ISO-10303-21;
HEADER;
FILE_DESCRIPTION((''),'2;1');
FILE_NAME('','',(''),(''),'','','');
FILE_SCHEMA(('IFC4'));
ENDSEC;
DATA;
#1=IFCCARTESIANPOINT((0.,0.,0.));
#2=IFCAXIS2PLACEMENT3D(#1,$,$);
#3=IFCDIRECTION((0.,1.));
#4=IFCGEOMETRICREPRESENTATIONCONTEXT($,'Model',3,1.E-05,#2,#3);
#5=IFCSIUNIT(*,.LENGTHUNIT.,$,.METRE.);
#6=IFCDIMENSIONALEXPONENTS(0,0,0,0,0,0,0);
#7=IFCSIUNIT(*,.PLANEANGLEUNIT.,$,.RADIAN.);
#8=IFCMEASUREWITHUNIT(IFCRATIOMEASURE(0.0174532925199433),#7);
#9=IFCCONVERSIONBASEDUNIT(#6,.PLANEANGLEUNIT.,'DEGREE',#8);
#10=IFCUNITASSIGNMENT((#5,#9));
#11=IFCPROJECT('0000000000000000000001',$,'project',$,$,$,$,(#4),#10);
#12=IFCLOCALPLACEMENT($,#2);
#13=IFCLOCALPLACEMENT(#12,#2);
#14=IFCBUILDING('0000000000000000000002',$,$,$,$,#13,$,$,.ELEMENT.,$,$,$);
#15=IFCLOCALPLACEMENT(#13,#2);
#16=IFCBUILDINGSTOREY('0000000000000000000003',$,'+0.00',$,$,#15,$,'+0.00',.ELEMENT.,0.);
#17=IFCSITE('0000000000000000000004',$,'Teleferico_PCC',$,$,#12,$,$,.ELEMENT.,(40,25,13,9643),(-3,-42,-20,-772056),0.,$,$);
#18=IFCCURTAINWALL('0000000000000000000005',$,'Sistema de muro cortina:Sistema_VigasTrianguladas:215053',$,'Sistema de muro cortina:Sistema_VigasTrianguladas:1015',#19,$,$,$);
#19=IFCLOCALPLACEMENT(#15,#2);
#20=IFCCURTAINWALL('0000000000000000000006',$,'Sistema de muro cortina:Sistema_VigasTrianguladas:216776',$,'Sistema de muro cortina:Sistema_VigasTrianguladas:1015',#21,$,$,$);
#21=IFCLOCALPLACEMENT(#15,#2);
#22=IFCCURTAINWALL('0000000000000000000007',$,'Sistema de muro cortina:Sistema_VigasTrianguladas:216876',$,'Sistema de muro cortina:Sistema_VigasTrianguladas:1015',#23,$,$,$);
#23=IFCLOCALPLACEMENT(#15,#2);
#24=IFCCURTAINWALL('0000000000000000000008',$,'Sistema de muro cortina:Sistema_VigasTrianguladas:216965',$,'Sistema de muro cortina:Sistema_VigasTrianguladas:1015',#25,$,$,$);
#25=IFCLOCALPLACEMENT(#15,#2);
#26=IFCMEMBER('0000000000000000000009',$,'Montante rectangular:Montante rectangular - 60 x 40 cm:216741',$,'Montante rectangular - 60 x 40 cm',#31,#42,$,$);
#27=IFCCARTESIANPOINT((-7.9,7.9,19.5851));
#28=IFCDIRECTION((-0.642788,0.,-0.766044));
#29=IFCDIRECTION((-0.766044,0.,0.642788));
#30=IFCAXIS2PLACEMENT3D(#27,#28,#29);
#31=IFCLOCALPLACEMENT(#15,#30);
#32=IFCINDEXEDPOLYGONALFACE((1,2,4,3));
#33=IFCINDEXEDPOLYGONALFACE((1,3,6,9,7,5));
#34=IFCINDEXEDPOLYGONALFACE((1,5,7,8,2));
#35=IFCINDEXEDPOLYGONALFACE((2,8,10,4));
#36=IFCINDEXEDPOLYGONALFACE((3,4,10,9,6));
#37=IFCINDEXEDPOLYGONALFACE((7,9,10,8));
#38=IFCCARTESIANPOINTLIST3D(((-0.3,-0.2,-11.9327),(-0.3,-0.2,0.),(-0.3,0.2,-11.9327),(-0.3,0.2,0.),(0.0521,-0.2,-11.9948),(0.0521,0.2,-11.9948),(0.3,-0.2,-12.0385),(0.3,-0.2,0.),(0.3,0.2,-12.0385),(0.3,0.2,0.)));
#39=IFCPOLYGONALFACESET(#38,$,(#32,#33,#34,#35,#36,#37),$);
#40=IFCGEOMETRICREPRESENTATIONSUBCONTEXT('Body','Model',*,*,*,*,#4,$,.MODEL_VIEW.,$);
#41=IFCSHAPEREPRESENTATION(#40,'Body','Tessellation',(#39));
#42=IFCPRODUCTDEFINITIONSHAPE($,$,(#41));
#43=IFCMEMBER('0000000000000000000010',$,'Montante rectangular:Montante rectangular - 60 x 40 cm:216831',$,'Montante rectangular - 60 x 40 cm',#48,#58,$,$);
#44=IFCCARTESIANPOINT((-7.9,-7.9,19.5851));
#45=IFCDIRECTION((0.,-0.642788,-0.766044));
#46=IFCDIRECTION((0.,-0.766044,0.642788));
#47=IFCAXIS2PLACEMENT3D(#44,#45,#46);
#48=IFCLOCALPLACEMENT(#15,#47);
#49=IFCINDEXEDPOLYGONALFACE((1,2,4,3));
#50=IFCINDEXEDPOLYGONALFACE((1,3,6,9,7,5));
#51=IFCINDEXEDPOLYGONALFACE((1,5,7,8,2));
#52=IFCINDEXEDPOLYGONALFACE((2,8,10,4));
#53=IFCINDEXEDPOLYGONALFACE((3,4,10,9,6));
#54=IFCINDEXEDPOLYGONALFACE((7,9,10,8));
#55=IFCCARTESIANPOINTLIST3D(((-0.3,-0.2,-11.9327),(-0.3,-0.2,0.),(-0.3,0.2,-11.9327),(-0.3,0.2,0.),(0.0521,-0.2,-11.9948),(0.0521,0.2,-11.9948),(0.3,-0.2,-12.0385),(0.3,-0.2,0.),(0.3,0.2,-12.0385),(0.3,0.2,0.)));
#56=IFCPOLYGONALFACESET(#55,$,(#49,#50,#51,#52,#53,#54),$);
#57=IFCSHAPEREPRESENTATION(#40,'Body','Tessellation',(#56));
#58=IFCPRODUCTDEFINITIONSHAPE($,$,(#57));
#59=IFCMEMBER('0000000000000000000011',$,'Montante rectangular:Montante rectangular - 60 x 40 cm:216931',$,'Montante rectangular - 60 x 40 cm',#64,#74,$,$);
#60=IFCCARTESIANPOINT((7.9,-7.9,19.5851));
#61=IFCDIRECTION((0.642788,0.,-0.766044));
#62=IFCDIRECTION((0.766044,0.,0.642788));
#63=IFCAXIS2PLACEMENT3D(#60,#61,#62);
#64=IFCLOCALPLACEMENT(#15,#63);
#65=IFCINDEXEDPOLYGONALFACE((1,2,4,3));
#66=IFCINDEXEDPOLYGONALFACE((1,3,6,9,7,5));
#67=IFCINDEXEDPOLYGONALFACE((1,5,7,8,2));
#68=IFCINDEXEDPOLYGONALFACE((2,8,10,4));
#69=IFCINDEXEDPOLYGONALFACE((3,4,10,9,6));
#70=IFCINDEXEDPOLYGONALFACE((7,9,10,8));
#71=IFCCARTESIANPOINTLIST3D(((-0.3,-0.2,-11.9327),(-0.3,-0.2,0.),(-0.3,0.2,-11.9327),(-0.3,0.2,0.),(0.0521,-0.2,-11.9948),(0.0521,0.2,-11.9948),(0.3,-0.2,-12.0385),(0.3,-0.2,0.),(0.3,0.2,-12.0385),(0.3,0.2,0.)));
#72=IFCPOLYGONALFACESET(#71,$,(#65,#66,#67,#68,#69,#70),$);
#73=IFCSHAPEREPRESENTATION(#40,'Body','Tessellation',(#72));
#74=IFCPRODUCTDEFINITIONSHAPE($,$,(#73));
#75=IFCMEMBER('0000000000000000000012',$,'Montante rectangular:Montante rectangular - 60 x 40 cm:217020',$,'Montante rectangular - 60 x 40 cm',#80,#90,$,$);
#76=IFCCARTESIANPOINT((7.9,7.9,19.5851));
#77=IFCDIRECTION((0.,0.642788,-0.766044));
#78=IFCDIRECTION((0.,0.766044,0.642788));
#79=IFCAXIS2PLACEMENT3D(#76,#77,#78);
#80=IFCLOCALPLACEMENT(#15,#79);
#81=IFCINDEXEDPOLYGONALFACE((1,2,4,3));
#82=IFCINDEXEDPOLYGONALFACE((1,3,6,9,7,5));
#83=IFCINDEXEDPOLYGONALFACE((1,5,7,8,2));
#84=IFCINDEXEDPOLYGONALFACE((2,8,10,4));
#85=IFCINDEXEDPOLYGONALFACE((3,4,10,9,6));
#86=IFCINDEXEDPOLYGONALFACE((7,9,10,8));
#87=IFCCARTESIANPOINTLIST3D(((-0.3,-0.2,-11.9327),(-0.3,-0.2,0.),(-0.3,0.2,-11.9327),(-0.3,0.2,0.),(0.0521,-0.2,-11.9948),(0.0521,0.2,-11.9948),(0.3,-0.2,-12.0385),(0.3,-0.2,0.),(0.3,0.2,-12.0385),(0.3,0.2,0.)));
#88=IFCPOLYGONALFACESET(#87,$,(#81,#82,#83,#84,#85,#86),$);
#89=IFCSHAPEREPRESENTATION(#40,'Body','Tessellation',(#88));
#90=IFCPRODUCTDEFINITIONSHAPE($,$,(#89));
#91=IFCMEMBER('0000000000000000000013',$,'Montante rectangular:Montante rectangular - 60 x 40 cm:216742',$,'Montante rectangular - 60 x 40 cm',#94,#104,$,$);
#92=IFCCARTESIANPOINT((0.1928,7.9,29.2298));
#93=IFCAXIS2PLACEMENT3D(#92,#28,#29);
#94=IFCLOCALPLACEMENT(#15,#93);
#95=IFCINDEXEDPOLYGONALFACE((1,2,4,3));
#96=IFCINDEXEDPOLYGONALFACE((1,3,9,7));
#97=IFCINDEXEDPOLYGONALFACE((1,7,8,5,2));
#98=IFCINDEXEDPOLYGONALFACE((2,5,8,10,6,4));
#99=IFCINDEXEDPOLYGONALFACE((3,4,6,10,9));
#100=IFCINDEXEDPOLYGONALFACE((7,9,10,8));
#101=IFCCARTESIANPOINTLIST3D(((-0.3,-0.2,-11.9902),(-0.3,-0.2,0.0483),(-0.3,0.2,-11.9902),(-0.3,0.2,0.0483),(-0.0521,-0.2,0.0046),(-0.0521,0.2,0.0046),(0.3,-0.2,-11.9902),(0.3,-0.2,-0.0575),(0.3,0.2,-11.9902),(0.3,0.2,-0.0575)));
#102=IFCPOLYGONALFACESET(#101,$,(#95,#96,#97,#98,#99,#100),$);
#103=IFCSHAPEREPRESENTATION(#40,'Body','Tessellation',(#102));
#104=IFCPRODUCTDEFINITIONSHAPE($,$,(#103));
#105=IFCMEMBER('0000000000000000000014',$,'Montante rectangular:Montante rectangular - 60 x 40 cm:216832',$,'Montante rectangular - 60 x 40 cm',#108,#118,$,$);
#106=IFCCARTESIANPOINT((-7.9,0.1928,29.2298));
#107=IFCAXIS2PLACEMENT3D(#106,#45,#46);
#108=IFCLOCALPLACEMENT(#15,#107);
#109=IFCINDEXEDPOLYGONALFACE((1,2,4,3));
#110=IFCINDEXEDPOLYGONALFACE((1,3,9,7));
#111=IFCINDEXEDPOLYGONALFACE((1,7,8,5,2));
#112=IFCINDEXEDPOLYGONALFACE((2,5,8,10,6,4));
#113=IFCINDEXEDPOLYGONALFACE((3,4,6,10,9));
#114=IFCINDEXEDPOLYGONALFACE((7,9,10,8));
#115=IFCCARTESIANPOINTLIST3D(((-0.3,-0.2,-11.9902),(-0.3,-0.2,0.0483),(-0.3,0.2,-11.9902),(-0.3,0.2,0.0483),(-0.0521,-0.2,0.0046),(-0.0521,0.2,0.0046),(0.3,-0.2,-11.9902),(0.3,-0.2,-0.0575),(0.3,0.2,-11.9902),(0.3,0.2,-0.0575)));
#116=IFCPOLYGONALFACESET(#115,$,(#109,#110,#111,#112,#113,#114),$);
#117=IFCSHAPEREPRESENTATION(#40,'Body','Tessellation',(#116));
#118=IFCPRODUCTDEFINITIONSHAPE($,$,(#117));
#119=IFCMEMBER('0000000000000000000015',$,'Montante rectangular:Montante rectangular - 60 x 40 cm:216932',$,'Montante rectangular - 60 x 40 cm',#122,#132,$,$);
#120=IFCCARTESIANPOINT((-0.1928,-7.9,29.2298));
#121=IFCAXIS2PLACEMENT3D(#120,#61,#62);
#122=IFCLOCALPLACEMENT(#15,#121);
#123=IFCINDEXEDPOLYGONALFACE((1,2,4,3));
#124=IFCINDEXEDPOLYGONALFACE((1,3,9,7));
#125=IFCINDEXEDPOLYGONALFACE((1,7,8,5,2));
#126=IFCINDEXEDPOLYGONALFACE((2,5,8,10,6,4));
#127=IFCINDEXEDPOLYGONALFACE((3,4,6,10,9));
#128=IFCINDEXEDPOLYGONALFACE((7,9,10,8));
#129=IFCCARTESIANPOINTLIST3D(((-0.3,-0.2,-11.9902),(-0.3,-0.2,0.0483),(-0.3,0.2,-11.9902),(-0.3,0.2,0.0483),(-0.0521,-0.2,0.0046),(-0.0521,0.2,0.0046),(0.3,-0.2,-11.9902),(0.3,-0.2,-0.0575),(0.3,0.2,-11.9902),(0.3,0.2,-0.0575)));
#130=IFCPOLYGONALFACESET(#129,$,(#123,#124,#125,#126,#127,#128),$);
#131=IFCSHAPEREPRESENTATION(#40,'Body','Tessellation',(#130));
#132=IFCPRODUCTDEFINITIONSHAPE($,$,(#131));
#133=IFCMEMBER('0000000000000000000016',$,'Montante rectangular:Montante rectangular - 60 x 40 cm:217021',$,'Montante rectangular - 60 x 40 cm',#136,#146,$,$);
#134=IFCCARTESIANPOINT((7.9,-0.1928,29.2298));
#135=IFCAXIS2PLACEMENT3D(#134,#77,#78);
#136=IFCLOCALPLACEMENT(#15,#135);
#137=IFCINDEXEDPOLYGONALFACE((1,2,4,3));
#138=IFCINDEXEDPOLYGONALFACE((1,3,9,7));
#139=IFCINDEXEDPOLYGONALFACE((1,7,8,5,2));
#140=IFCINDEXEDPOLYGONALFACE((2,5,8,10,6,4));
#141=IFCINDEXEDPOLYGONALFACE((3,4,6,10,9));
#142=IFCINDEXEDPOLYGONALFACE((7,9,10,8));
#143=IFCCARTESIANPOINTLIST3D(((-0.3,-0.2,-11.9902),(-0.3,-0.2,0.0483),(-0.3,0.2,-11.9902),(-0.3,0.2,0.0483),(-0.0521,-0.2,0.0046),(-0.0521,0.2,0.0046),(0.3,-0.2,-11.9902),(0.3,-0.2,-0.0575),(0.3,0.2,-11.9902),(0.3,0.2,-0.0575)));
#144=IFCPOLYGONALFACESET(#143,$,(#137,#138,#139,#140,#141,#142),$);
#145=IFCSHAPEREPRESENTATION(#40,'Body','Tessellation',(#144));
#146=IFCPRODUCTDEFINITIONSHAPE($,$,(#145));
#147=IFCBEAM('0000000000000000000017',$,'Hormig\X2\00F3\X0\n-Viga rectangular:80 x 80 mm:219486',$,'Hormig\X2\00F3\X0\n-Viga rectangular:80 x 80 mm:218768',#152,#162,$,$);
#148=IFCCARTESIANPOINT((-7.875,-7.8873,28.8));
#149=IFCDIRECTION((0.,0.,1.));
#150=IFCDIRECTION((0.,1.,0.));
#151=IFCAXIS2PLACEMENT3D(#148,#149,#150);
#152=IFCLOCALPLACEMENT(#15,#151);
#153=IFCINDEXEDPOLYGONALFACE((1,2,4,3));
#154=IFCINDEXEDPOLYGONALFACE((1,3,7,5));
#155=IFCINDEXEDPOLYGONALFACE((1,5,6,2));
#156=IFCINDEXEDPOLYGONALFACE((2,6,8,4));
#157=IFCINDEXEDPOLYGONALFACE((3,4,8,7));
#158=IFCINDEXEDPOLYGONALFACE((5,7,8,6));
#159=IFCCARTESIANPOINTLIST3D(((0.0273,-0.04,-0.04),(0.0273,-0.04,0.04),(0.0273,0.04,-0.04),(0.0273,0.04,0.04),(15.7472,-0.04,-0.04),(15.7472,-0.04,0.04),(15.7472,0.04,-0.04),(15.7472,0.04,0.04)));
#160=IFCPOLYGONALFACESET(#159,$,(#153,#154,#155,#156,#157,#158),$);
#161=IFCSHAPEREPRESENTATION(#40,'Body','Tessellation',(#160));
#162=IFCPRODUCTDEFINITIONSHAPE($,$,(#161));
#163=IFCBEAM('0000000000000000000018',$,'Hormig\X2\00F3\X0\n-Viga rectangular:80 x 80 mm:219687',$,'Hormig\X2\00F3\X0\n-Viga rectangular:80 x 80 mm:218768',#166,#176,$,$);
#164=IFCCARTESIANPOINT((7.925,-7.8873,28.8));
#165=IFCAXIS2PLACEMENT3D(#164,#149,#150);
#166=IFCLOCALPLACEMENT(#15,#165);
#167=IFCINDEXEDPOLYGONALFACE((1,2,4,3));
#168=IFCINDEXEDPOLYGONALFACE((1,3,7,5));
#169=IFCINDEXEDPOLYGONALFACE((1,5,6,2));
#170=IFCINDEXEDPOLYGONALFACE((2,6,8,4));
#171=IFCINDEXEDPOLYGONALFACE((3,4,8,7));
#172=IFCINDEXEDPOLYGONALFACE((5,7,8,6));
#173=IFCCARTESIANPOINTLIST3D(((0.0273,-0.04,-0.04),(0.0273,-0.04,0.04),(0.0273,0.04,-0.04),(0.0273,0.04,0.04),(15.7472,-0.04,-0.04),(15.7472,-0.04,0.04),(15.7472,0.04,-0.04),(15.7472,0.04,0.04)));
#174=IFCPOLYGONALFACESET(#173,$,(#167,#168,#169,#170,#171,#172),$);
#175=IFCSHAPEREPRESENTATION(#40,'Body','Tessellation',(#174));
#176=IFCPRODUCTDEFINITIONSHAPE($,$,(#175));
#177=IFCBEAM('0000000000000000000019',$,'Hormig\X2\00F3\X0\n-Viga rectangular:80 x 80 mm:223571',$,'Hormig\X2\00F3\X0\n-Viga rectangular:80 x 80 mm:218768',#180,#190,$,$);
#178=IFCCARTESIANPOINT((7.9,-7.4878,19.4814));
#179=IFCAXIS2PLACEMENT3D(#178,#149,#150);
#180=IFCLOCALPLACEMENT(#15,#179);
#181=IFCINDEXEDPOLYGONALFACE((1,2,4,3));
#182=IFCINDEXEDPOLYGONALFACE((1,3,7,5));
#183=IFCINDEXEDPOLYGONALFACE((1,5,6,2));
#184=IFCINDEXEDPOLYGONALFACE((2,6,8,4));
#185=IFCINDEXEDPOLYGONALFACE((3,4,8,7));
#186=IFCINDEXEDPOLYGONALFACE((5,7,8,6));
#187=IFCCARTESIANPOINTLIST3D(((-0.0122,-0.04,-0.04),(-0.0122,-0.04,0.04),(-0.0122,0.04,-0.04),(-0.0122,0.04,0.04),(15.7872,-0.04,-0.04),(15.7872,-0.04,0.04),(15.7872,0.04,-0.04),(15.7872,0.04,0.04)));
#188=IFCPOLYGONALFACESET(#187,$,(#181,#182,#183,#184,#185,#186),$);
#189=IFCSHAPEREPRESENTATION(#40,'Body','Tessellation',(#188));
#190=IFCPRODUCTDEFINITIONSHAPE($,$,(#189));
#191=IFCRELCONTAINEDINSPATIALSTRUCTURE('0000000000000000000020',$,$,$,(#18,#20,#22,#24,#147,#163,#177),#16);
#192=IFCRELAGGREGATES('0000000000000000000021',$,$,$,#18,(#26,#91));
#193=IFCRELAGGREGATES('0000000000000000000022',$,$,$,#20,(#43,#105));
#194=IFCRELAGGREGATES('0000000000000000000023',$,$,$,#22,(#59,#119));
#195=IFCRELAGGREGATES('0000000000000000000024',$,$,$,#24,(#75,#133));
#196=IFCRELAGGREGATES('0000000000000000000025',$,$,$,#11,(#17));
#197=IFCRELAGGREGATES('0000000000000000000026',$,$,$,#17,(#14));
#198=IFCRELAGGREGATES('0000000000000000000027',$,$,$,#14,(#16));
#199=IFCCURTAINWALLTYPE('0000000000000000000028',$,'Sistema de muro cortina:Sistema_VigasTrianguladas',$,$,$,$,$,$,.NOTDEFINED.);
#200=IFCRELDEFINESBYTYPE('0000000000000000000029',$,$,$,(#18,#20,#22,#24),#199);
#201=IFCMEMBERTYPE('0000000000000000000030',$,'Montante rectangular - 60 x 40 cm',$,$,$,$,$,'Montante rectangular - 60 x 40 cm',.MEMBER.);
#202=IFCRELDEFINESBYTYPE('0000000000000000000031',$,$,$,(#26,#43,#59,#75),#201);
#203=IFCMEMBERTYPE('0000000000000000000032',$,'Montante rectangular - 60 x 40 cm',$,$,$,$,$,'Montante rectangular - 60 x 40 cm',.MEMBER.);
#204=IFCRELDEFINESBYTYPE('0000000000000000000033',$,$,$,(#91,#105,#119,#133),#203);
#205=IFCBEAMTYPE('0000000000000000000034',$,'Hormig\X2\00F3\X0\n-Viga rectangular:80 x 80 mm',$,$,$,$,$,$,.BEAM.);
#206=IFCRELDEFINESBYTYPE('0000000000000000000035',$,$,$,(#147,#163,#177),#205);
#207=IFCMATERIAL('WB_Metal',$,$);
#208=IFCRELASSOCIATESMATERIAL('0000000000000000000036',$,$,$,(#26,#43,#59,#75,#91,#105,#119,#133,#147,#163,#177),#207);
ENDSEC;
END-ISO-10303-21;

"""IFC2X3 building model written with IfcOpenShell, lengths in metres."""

from ifc_helpers import new_model, entity, si_unit, converted_unit, direction, frame, frame_2d, origin, origin_2d_with_axis, place, context, subcontext, project, spatial, polyline, rectangle, extrude, clip, bounded_halfspace, source, transform, mapped, material, type_object, type_shapes, element, aggregate, save


model = new_model("IFC2X3")

# Units and contexts
model_context = context("Model", 3, precision=1e-05, world=origin(), true_north=direction((0.0, 1.0)))
body_context = subcontext(model_context, "Body", "Model", "MODEL_VIEW")
ifc_project = project(units=[si_unit("LENGTHUNIT", "METRE"), converted_unit("PLANEANGLEUNIT", "DEGREE", entity("IfcRatioMeasure", 0.0174532925199433), si_unit("PLANEANGLEUNIT", "RADIAN"), dimensions=[0, 0, 0, 0, 0, 0, 0])], contexts=[model_context])

# Site, building, storey
site_placement = place(None, origin())
site = spatial("IfcSite", under=ifc_project, at=site_placement, Name="Teleferico_PCC", CompositionType="ELEMENT", RefLatitude=(40, 25, 13, 9643), RefLongitude=(-3, -42, -20, -772056), RefElevation=0.0)
building_placement = place(site_placement, origin())
building = spatial("IfcBuilding", under=site, at=building_placement, CompositionType="ELEMENT")
storey_placement = place(building_placement, origin())
storey = spatial("IfcBuildingStorey", under=building, at=storey_placement, Name="+0.00", LongName="+0.00", CompositionType="ELEMENT", Elevation=0.0)

# Curtain walls
curtain_wall_type = type_object("IfcCurtainWallType", Name="Sistema de muro cortina:Sistema_VigasTrianguladas", PredefinedType="NOTDEFINED")
curtain_wall_1_placement = place(storey_placement, origin())
curtain_wall_1 = element("IfcCurtainWall", 1, at=curtain_wall_1_placement, inside=storey, type_object=curtain_wall_type, Name="Sistema de muro cortina:Sistema_VigasTrianguladas:215053", ObjectType="Sistema de muro cortina:Sistema_VigasTrianguladas:1015")
ifc_material = material(Name="WB_Metal")
curtain_wall_2_placement = place(storey_placement, origin())
curtain_wall_2 = element("IfcCurtainWall", 2, at=curtain_wall_2_placement, inside=storey, type_object=curtain_wall_type, Name="Sistema de muro cortina:Sistema_VigasTrianguladas:216776", ObjectType="Sistema de muro cortina:Sistema_VigasTrianguladas:1015")
curtain_wall_3_placement = place(storey_placement, origin())
curtain_wall_3 = element("IfcCurtainWall", 3, at=curtain_wall_3_placement, inside=storey, type_object=curtain_wall_type, Name="Sistema de muro cortina:Sistema_VigasTrianguladas:216876", ObjectType="Sistema de muro cortina:Sistema_VigasTrianguladas:1015")
curtain_wall_4_placement = place(storey_placement, origin())
curtain_wall_4 = element("IfcCurtainWall", 4, at=curtain_wall_4_placement, inside=storey, type_object=curtain_wall_type, Name="Sistema de muro cortina:Sistema_VigasTrianguladas:216965", ObjectType="Sistema de muro cortina:Sistema_VigasTrianguladas:1015")

# Members
member_type_1 = type_object("IfcMemberType", Name="Montante rectangular - 60 x 40 cm", ElementType="Montante rectangular - 60 x 40 cm", PredefinedType="MEMBER")
shared_shape_1 = source(origin(), body_context, "Body", "Clipping", [
    clip(clip(extrude(rectangle(XDim=0.4, YDim=0.6, at=origin_2d_with_axis()), frame((0.0, 0.0, -12.0385), z_axis=(0.0, 0.0, 1.0), x_axis=(0.0, -1.0, 0.0)), (0.0, 0.0, 1.0), 12.0385), bounded_halfspace(frame((12.1556, 91.44, -14.1289), z_axis=(-0.173648, 0.0, -0.984808), x_axis=(-0.984808, 0.0, 0.173648)), False, frame((0.0, 0.0, -12.0385), z_axis=(0.0, 0.0, 1.0), x_axis=(0.0, -1.0, 0.0)), polyline([(0.2, 0.3), (0.2, 0.0521), (-0.2, 0.0521), (-0.2, 0.3), (0.2, 0.3)]))), bounded_halfspace(frame((0.0521, 91.44, -11.9948), z_axis=(-0.173648, 0.0, -0.984808), x_axis=(-0.984808, 0.0, 0.173648)), False, frame((0.0, 0.0, -12.0385), z_axis=(0.0, 0.0, 1.0), x_axis=(0.0, -1.0, 0.0)), polyline([(0.2, 0.0521), (0.2, -0.3), (-0.2, -0.3), (-0.2, 0.0521), (0.2, 0.0521)]))),
])
type_shapes(member_type_1, [shared_shape_1])
member_1_placement = place(storey_placement, frame((-7.9, 7.9, 19.5851), z_axis=(-0.642788, 0.0, -0.766044), x_axis=(-0.766044, 0.0, 0.642788)))
member_1 = element("IfcMember", 5, at=member_1_placement, type_object=member_type_1, material=ifc_material, Name="Montante rectangular:Montante rectangular - 60 x 40 cm:216741", ObjectType="Montante rectangular - 60 x 40 cm", context=body_context, shape_type="MappedRepresentation", body=[
    mapped(shared_shape_1, transform((0.0, 0.0, 0.0), scale=1.0)),
])
member_2_placement = place(storey_placement, frame((-7.9, -7.9, 19.5851), z_axis=(0.0, -0.642788, -0.766044), x_axis=(0.0, -0.766044, 0.642788)))
member_2 = element("IfcMember", 6, at=member_2_placement, type_object=member_type_1, material=ifc_material, Name="Montante rectangular:Montante rectangular - 60 x 40 cm:216831", ObjectType="Montante rectangular - 60 x 40 cm", context=body_context, shape_type="MappedRepresentation", body=[
    mapped(shared_shape_1, transform((0.0, 0.0, 0.0), scale=1.0)),
])
member_3_placement = place(storey_placement, frame((7.9, -7.9, 19.5851), z_axis=(0.642788, 0.0, -0.766044), x_axis=(0.766044, 0.0, 0.642788)))
member_3 = element("IfcMember", 7, at=member_3_placement, type_object=member_type_1, material=ifc_material, Name="Montante rectangular:Montante rectangular - 60 x 40 cm:216931", ObjectType="Montante rectangular - 60 x 40 cm", context=body_context, shape_type="MappedRepresentation", body=[
    mapped(shared_shape_1, transform((0.0, 0.0, 0.0), scale=1.0)),
])
member_4_placement = place(storey_placement, frame((7.9, 7.9, 19.5851), z_axis=(0.0, 0.642788, -0.766044), x_axis=(0.0, 0.766044, 0.642788)))
member_4 = element("IfcMember", 8, at=member_4_placement, type_object=member_type_1, material=ifc_material, Name="Montante rectangular:Montante rectangular - 60 x 40 cm:217020", ObjectType="Montante rectangular - 60 x 40 cm", context=body_context, shape_type="MappedRepresentation", body=[
    mapped(shared_shape_1, transform((0.0, 0.0, 0.0), scale=1.0)),
])
member_type_2 = type_object("IfcMemberType", Name="Montante rectangular - 60 x 40 cm", ElementType="Montante rectangular - 60 x 40 cm", PredefinedType="MEMBER")
shared_shape_2 = source(origin(), body_context, "Body", "Clipping", [
    clip(clip(extrude(rectangle(XDim=0.4, YDim=0.6, at=origin_2d_with_axis()), frame((0.0, 0.0, -11.9902), z_axis=(0.0, 0.0, 1.0), x_axis=(0.0, -1.0, 0.0)), (0.0, 0.0, 1.0), 12.0385), bounded_halfspace(frame((12.0514, -91.44, -2.1296), z_axis=(0.173648, 0.0, 0.984808), x_axis=(-0.984808, 0.0, 0.173648)), False, frame((0.0, 0.0, -11.9902), z_axis=(0.0, 0.0, 1.0), x_axis=(0.0, -1.0, 0.0)), polyline([(0.2, 0.3), (-0.2, 0.3), (-0.2, -0.0521), (0.2, -0.0521), (0.2, 0.3)]))), bounded_halfspace(frame((-0.0521, -91.44, 0.0046), z_axis=(0.173648, 0.0, 0.984808), x_axis=(-0.984808, 0.0, 0.173648)), False, frame((0.0, 0.0, -11.9902), z_axis=(0.0, 0.0, 1.0), x_axis=(0.0, -1.0, 0.0)), polyline([(-0.2, -0.0521), (-0.2, -0.3), (0.2, -0.3), (0.2, -0.0521), (-0.2, -0.0521)]))),
])
type_shapes(member_type_2, [shared_shape_2])
member_5_placement = place(storey_placement, frame((0.1928, 7.9, 29.2298), z_axis=(-0.642788, 0.0, -0.766044), x_axis=(-0.766044, 0.0, 0.642788)))
member_5 = element("IfcMember", 9, at=member_5_placement, type_object=member_type_2, material=ifc_material, Name="Montante rectangular:Montante rectangular - 60 x 40 cm:216742", ObjectType="Montante rectangular - 60 x 40 cm", context=body_context, shape_type="MappedRepresentation", body=[
    mapped(shared_shape_2, transform((0.0, 0.0, 0.0), scale=1.0)),
])
aggregate(curtain_wall_1, [member_1, member_5])
member_6_placement = place(storey_placement, frame((-7.9, 0.1928, 29.2298), z_axis=(0.0, -0.642788, -0.766044), x_axis=(0.0, -0.766044, 0.642788)))
member_6 = element("IfcMember", 10, at=member_6_placement, type_object=member_type_2, material=ifc_material, Name="Montante rectangular:Montante rectangular - 60 x 40 cm:216832", ObjectType="Montante rectangular - 60 x 40 cm", context=body_context, shape_type="MappedRepresentation", body=[
    mapped(shared_shape_2, transform((0.0, 0.0, 0.0), scale=1.0)),
])
aggregate(curtain_wall_2, [member_2, member_6])
member_7_placement = place(storey_placement, frame((-0.1928, -7.9, 29.2298), z_axis=(0.642788, 0.0, -0.766044), x_axis=(0.766044, 0.0, 0.642788)))
member_7 = element("IfcMember", 11, at=member_7_placement, type_object=member_type_2, material=ifc_material, Name="Montante rectangular:Montante rectangular - 60 x 40 cm:216932", ObjectType="Montante rectangular - 60 x 40 cm", context=body_context, shape_type="MappedRepresentation", body=[
    mapped(shared_shape_2, transform((0.0, 0.0, 0.0), scale=1.0)),
])
aggregate(curtain_wall_3, [member_3, member_7])
member_8_placement = place(storey_placement, frame((7.9, -0.1928, 29.2298), z_axis=(0.0, 0.642788, -0.766044), x_axis=(0.0, 0.766044, 0.642788)))
member_8 = element("IfcMember", 12, at=member_8_placement, type_object=member_type_2, material=ifc_material, Name="Montante rectangular:Montante rectangular - 60 x 40 cm:217021", ObjectType="Montante rectangular - 60 x 40 cm", context=body_context, shape_type="MappedRepresentation", body=[
    mapped(shared_shape_2, transform((0.0, 0.0, 0.0), scale=1.0)),
])
aggregate(curtain_wall_4, [member_4, member_8])

# Beams
beam_type = type_object("IfcBeamType", Name="Hormigón-Viga rectangular:80 x 80 mm", PredefinedType="BEAM")
beam_1_placement = place(storey_placement, frame((-7.875, -7.8873, 28.8), z_axis=(0.0, 0.0, 1.0), x_axis=(0.0, 1.0, 0.0)))
element("IfcBeam", 13, at=beam_1_placement, inside=storey, type_object=beam_type, material=ifc_material, Name="Hormigón-Viga rectangular:80 x 80 mm:219486", ObjectType="Hormigón-Viga rectangular:80 x 80 mm:218768", context=body_context, shape_type="SweptSolid", body=[
    extrude(rectangle(XDim=0.08, YDim=0.08, at=frame_2d((0.0, 0.0), x_axis=(1.0, 0.0))), frame((0.0273, 0.0, 0.0), z_axis=(1.0, 0.0, 0.0), x_axis=(0.0, 0.0, -1.0)), (0.0, 0.0, 1.0), 15.7199),
])
beam_2_placement = place(storey_placement, frame((7.925, -7.8873, 28.8), z_axis=(0.0, 0.0, 1.0), x_axis=(0.0, 1.0, 0.0)))
element("IfcBeam", 14, at=beam_2_placement, inside=storey, type_object=beam_type, material=ifc_material, Name="Hormigón-Viga rectangular:80 x 80 mm:219687", ObjectType="Hormigón-Viga rectangular:80 x 80 mm:218768", context=body_context, shape_type="SweptSolid", body=[
    extrude(rectangle(XDim=0.08, YDim=0.08, at=frame_2d((0.0, 0.0), x_axis=(1.0, 0.0))), frame((0.0273, 0.0, 0.0), z_axis=(1.0, 0.0, 0.0), x_axis=(0.0, 0.0, -1.0)), (0.0, 0.0, 1.0), 15.7199),
])
beam_3_placement = place(storey_placement, frame((7.9, -7.4878, 19.4814), z_axis=(0.0, 0.0, 1.0), x_axis=(0.0, 1.0, 0.0)))
element("IfcBeam", 15, at=beam_3_placement, inside=storey, type_object=beam_type, material=ifc_material, Name="Hormigón-Viga rectangular:80 x 80 mm:223571", ObjectType="Hormigón-Viga rectangular:80 x 80 mm:218768", context=body_context, shape_type="SweptSolid", body=[
    extrude(rectangle(XDim=0.08, YDim=0.08, at=frame_2d((0.0, 0.0), x_axis=(1.0, 0.0))), frame((-0.0122, 0.0, 0.0), z_axis=(1.0, 0.0, 0.0), x_axis=(0.0, 0.0, -1.0)), (0.0, 0.0, 1.0), 15.7994),
])

save(model, "model.ifc")
